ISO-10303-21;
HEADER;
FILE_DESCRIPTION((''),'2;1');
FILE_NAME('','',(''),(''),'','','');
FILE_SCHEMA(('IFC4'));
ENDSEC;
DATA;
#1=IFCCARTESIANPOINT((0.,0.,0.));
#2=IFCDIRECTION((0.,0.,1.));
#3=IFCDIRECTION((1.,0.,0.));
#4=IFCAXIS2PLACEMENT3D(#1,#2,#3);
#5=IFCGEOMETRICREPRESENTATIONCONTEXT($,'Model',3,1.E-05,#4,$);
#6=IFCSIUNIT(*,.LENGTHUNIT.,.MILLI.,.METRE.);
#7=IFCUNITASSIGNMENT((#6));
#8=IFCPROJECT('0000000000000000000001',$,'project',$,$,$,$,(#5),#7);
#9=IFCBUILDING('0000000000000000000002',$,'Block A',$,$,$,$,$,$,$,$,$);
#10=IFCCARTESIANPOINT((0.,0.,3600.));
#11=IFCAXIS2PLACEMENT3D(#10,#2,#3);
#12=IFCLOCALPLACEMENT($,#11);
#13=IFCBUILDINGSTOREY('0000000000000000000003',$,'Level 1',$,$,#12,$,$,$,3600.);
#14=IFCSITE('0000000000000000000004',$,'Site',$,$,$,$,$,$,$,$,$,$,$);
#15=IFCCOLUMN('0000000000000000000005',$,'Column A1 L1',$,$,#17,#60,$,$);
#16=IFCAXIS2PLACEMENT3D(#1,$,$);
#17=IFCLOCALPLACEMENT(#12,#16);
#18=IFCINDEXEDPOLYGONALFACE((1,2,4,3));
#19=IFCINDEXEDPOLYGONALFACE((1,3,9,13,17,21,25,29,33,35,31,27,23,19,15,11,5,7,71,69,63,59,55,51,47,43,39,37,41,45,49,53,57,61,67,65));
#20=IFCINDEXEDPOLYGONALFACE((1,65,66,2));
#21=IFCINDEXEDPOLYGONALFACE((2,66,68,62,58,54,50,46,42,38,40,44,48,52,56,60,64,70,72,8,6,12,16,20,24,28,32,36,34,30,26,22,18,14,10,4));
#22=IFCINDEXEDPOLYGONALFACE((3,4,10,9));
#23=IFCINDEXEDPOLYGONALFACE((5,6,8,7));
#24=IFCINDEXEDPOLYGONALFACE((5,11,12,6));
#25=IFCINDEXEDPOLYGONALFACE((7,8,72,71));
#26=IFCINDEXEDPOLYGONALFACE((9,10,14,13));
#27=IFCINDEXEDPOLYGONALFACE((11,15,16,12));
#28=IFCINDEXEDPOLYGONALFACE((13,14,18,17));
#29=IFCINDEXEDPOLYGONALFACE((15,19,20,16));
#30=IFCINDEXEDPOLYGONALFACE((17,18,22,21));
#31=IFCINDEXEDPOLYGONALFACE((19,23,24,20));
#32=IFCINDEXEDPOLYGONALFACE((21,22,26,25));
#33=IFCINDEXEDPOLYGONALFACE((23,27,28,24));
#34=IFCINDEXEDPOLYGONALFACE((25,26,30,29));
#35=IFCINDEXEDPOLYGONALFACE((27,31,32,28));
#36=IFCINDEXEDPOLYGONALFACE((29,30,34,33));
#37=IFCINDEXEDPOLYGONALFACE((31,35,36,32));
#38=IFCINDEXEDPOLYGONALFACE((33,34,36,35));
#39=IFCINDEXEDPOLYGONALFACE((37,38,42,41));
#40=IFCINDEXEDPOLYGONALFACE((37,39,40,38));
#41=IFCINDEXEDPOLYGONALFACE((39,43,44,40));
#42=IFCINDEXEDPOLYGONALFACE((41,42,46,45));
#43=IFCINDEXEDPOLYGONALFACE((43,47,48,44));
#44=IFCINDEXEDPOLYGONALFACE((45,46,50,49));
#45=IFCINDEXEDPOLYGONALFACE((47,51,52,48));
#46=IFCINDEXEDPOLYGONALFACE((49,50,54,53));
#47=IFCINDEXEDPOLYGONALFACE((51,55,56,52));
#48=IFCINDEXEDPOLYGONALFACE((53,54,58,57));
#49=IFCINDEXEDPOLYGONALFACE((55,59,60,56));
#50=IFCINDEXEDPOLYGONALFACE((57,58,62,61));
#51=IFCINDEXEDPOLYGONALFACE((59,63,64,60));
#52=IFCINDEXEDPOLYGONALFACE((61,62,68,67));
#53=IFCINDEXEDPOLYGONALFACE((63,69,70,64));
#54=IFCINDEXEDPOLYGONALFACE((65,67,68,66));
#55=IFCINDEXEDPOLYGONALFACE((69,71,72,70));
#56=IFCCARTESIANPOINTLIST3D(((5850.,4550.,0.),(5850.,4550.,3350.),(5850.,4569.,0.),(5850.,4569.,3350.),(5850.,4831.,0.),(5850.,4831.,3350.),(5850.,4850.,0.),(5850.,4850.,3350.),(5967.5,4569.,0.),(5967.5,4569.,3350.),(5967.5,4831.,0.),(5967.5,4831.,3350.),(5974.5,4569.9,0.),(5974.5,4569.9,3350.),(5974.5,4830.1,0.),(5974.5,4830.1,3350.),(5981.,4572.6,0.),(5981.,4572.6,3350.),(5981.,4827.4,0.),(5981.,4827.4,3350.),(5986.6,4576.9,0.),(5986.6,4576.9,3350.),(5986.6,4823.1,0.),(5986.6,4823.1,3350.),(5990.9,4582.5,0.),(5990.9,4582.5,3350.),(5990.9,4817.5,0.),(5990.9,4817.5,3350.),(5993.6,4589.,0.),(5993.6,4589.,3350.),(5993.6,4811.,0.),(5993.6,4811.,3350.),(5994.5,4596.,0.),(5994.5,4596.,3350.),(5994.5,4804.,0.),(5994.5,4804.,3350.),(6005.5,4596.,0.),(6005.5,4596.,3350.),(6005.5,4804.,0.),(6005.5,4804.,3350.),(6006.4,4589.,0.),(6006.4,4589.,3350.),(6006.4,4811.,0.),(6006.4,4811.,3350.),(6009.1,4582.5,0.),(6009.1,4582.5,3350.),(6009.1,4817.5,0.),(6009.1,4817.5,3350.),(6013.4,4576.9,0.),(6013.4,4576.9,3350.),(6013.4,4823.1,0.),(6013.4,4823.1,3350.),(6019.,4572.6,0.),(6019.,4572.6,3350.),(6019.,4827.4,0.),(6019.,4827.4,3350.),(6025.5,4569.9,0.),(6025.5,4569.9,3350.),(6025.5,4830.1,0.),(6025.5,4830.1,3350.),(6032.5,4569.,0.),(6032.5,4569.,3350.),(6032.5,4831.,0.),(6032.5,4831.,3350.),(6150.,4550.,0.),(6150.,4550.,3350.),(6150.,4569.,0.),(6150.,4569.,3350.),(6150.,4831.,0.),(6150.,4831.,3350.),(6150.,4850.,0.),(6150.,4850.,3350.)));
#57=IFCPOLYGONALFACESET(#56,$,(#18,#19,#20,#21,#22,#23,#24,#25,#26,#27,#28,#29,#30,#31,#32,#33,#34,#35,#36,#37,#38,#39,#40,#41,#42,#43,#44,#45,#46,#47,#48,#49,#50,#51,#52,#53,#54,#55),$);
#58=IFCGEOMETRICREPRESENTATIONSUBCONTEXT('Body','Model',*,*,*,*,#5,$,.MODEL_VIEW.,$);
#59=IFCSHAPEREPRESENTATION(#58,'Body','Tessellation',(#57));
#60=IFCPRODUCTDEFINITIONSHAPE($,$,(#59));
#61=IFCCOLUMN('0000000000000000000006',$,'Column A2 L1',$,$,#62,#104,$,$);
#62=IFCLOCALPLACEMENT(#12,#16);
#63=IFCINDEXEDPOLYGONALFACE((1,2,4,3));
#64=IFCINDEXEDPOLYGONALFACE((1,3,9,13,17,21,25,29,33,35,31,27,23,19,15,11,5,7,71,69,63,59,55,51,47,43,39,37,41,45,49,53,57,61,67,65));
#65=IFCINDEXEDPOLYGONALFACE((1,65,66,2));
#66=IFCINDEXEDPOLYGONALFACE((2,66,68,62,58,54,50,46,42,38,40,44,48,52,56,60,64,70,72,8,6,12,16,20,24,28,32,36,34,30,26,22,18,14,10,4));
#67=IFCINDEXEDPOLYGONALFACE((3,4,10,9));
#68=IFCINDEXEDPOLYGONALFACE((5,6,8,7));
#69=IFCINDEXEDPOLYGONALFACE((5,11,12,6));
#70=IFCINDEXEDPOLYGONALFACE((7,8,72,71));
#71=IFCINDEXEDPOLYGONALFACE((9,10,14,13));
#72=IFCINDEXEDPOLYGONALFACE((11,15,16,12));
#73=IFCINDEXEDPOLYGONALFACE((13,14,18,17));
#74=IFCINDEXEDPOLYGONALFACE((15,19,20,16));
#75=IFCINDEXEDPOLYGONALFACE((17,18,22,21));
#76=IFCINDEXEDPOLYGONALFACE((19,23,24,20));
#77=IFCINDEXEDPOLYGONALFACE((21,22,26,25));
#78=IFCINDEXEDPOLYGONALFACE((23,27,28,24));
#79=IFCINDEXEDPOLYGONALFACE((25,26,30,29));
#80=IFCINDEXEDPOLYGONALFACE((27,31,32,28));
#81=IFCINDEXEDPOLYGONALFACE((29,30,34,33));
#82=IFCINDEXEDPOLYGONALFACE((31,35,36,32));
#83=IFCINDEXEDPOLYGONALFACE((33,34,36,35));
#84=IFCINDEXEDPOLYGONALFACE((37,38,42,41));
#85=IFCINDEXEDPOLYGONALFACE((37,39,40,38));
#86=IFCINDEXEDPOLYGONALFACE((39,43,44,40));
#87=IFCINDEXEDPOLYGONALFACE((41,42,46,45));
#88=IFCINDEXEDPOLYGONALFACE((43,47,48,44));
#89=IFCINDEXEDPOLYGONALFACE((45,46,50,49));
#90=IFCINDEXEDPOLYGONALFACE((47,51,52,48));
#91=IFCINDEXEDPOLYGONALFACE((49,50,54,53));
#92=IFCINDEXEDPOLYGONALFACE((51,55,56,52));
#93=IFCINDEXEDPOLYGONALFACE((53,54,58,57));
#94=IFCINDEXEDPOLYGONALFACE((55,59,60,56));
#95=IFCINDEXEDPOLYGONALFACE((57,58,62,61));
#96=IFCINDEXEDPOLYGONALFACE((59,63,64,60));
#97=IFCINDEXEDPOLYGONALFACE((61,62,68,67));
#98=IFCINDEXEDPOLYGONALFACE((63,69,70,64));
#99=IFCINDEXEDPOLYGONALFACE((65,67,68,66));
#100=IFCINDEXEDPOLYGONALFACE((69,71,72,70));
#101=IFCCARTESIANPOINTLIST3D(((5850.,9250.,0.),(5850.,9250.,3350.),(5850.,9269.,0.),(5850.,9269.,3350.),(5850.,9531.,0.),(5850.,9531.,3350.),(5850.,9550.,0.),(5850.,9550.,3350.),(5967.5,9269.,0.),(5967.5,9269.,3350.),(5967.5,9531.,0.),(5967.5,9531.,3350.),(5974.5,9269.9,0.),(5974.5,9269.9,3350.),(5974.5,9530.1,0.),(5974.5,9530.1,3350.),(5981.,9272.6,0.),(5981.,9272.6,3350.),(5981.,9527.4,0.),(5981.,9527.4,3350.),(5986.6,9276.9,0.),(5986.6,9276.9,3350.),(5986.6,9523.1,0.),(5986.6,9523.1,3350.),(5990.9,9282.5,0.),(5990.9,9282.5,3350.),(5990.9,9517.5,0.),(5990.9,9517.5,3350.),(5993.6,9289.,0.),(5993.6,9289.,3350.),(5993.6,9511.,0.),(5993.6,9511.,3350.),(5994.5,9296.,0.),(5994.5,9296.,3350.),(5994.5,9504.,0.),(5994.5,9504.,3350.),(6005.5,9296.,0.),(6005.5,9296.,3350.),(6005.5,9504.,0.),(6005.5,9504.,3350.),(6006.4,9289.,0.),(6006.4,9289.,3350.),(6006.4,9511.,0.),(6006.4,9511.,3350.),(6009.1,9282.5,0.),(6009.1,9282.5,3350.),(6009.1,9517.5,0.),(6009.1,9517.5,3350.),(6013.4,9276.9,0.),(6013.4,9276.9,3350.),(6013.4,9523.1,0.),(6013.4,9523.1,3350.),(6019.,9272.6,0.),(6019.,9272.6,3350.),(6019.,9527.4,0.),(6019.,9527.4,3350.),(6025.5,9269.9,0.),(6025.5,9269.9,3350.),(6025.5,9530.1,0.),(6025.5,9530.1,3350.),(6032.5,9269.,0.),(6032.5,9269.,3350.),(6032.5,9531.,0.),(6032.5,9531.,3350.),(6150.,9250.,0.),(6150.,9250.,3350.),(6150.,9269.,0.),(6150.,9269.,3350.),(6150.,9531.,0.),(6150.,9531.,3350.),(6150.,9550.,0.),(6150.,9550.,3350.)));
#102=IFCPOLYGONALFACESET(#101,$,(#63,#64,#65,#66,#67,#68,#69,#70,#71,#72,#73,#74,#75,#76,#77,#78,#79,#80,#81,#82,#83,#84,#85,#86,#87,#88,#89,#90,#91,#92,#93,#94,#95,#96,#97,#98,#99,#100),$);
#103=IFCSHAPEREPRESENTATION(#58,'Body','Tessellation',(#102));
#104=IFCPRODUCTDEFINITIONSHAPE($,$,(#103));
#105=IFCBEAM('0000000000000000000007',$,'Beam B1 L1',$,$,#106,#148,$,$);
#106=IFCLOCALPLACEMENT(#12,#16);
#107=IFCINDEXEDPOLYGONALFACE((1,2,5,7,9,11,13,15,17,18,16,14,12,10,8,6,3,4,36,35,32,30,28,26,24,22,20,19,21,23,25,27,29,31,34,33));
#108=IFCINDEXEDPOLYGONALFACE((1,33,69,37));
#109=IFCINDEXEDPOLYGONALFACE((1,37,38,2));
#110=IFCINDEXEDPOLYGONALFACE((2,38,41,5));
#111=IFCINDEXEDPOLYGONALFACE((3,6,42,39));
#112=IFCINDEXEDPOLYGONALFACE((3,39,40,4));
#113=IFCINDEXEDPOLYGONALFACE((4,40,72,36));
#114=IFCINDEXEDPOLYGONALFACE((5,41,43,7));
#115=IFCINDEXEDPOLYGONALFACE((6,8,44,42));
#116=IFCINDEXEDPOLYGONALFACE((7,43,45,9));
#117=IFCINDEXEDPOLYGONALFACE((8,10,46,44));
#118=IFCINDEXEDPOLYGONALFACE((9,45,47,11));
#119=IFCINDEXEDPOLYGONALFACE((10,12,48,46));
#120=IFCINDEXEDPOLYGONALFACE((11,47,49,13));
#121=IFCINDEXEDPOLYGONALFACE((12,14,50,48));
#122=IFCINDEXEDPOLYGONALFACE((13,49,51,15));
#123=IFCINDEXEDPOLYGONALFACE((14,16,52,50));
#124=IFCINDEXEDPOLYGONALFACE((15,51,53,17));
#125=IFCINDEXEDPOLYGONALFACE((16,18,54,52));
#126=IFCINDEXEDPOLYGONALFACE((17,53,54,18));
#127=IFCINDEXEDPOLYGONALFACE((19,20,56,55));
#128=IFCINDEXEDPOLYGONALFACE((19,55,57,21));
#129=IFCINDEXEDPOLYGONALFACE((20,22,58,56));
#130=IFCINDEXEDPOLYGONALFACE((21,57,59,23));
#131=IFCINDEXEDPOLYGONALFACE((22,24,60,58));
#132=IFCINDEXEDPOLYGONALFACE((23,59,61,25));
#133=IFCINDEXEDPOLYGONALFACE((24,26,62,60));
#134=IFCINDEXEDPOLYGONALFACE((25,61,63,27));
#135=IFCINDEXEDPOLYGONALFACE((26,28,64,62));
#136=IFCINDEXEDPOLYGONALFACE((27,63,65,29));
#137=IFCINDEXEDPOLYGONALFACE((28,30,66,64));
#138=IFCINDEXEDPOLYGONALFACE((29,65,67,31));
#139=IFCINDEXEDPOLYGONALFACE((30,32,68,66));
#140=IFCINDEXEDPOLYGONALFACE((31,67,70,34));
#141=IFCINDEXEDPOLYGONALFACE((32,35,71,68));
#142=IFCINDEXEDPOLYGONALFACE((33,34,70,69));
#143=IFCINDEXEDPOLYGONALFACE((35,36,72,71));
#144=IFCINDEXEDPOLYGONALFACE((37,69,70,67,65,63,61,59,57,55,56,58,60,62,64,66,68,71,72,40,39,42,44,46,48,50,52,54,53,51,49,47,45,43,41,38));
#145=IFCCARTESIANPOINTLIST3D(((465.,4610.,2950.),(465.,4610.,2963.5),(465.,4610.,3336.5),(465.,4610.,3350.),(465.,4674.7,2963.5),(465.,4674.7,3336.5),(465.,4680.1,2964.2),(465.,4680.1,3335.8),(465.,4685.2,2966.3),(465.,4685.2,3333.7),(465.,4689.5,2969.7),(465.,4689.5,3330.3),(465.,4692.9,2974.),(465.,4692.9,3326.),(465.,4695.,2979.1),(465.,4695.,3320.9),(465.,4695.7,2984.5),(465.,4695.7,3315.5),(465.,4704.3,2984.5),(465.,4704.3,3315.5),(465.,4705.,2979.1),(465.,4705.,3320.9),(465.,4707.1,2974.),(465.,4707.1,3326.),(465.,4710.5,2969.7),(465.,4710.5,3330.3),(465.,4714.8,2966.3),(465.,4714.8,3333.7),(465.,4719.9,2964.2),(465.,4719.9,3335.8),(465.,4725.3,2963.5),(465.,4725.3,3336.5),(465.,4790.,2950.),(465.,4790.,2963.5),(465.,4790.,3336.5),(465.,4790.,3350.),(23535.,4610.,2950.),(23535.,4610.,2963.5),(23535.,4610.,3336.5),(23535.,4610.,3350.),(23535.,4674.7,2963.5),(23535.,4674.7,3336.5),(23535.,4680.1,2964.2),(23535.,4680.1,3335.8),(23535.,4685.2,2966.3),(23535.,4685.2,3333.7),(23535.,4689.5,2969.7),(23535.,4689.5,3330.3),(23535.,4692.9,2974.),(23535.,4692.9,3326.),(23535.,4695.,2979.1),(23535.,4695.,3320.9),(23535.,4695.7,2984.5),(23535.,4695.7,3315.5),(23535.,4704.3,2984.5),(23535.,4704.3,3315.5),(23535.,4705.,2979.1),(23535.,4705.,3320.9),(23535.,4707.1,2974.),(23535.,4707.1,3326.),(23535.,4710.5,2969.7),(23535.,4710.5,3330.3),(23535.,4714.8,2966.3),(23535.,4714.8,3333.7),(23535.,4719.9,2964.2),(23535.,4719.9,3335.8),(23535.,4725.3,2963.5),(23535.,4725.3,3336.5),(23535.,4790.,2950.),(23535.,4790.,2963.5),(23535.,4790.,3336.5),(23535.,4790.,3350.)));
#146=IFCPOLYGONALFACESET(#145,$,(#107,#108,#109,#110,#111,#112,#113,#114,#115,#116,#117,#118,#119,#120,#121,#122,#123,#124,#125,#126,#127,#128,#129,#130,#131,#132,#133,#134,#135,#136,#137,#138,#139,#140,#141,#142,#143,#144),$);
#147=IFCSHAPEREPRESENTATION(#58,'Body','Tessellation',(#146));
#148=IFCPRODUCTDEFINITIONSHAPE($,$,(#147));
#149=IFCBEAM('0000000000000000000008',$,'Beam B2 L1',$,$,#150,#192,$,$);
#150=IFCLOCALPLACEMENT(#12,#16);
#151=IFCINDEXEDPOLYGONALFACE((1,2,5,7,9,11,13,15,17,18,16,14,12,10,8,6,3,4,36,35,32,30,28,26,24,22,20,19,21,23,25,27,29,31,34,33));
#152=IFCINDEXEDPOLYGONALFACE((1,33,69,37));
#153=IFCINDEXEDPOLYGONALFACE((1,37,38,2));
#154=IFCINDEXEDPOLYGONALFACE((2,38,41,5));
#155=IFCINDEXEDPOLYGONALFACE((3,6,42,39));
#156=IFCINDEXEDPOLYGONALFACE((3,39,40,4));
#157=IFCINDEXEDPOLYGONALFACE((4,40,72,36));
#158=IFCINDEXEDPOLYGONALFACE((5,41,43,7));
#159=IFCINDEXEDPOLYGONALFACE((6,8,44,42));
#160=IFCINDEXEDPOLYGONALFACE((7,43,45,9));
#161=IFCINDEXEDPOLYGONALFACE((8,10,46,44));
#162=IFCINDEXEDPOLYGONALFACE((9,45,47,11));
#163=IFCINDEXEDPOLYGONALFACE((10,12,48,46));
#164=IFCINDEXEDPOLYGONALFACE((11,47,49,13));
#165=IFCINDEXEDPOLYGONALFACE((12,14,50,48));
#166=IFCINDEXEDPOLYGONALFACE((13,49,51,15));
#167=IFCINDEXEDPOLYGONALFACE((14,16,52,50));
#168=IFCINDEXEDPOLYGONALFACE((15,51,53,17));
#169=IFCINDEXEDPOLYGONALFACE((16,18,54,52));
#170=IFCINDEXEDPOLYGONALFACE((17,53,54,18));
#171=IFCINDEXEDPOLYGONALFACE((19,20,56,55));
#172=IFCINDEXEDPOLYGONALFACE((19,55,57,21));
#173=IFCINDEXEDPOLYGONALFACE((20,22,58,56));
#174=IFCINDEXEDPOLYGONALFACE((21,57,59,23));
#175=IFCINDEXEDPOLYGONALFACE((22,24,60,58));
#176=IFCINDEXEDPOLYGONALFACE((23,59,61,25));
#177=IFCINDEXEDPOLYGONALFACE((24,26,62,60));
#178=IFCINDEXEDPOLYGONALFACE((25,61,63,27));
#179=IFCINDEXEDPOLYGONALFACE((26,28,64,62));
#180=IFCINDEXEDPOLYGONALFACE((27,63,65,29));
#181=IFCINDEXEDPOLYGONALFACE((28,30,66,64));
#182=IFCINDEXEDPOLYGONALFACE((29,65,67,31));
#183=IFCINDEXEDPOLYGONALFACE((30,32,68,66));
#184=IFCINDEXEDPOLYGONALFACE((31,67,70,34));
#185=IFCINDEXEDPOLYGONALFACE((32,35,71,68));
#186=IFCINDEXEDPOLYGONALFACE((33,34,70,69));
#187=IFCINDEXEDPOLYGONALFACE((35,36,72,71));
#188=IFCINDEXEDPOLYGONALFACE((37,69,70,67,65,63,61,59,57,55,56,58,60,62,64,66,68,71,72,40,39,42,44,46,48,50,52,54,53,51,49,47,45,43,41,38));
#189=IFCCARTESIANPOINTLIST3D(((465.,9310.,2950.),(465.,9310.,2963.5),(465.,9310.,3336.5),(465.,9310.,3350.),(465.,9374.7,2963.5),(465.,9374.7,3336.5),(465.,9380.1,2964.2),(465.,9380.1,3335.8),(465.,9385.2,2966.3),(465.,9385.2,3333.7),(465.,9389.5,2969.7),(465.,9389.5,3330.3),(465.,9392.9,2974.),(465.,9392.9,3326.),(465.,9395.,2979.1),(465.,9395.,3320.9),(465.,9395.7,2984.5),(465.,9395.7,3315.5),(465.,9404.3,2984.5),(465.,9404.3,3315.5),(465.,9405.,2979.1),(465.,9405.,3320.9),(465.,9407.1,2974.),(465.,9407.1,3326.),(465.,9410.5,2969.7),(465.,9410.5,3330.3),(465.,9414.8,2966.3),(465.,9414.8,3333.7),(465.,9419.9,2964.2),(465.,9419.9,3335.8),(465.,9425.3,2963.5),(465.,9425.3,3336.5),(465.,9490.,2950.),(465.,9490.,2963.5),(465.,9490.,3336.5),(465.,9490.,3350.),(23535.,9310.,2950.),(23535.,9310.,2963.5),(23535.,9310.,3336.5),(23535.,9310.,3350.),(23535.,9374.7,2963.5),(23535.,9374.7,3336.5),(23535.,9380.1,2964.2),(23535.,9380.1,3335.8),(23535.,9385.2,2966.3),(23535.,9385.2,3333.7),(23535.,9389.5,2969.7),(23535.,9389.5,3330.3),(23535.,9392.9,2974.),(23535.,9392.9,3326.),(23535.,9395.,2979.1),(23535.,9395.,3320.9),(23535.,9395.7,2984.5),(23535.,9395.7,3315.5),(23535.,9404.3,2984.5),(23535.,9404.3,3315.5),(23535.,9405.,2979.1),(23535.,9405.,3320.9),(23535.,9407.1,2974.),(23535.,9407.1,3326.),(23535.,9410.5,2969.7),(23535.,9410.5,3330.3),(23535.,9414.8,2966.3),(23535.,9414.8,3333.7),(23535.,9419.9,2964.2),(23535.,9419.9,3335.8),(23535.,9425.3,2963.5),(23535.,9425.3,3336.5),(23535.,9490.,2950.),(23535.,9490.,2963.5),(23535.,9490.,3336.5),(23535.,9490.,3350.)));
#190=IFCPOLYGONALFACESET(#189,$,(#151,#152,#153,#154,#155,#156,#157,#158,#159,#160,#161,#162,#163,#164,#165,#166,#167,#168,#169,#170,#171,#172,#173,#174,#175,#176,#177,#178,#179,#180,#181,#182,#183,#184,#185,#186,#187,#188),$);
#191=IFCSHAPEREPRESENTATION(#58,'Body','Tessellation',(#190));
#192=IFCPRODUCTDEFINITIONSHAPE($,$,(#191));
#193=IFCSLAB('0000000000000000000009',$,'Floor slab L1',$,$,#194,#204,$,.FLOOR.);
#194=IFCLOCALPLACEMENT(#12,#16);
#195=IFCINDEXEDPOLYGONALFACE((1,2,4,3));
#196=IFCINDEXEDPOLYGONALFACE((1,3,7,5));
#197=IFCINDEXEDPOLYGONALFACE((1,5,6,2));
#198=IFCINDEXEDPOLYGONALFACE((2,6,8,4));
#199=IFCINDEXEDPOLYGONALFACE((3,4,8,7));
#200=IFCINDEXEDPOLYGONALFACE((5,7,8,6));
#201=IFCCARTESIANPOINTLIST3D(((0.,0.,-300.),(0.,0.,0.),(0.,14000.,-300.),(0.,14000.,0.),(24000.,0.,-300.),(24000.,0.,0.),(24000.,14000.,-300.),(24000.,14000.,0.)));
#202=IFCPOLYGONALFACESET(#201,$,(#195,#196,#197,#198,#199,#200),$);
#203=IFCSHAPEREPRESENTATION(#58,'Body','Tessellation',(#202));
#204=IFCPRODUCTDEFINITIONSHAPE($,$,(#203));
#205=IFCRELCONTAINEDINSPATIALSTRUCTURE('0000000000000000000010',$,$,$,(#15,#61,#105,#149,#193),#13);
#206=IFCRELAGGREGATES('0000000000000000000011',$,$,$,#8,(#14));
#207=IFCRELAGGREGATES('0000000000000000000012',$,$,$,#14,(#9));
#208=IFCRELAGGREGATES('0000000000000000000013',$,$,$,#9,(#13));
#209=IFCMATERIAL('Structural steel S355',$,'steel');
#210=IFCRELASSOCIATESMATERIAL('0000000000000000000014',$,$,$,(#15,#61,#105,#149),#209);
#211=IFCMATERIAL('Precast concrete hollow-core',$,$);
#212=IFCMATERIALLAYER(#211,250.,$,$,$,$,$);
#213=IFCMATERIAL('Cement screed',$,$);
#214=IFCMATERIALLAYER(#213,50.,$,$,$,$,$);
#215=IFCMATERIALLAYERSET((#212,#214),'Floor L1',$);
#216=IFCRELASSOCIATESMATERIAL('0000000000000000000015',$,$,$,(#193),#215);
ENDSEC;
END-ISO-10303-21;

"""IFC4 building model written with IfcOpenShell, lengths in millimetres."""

from ifc_helpers import new_model, si_unit, frame, origin_with_axes, place, context, subcontext, project, spatial, indexed_curve, i_section, outline, extrude, material, layer, layer_set, layer_usage, material_profile, profile_set, element, save


model = new_model("IFC4")

# Units and contexts
model_context = context("Model", 3, precision=1e-05, world=origin_with_axes())
body_context = subcontext(model_context, "Body", "Model", "MODEL_VIEW")
ifc_project = project(units=[si_unit("LENGTHUNIT", "METRE", prefix="MILLI")], contexts=[model_context])

# Site, building, storey
site = spatial("IfcSite", under=ifc_project, Name="Site")
building = spatial("IfcBuilding", under=site, Name="Block A")
storey_placement = place(None, frame((0.0, 0.0, 3600.0), z_axis=(0.0, 0.0, 1.0), x_axis=(1.0, 0.0, 0.0)))
storey = spatial("IfcBuildingStorey", under=building, at=storey_placement, Name="Level 1", Elevation=3600.0)

# Columns
ifc_material_1 = material(Name="Structural steel S355", Category="steel")
ifc_material_profile_1 = material_profile(ifc_material_1, i_section(OverallWidth=300.0, OverallDepth=300.0, WebThickness=11.0, FlangeThickness=19.0, FilletRadius=27.0))
ifc_profile_set_1 = profile_set([ifc_material_profile_1], Name="HEB 300")
for number, where, z_axis, x_axis, name in (
    (1, (6000.0, 4700.0, 0.0), (0.0, 0.0, 1.0), (1.0, 0.0, 0.0), "Column A1 L1"),
    (2, (6000.0, 9400.0, 0.0), (0.0, 0.0, 1.0), (1.0, 0.0, 0.0), "Column A2 L1"),
):
    element("IfcColumn", number, at=place(storey_placement, frame(where, z_axis=z_axis, x_axis=x_axis)), inside=storey, material=ifc_profile_set_1, Name=name, context=body_context, shape_type="SweptSolid", body=[
        extrude(i_section(OverallWidth=300.0, OverallDepth=300.0, WebThickness=11.0, FlangeThickness=19.0, FilletRadius=27.0), origin_with_axes(), (0.0, 0.0, 1.0), 3350.0),
    ])

# Beams
ifc_material_profile_2 = material_profile(ifc_material_1, i_section(OverallWidth=180.0, OverallDepth=400.0, WebThickness=8.6, FlangeThickness=13.5, FilletRadius=21.0))
ifc_profile_set_2 = profile_set([ifc_material_profile_2], Name="IPE 400")
for number, where, z_axis, x_axis, name in (
    (3, (465.0, 4700.0, 3150.0), (1.0, 0.0, 0.0), (0.0, 1.0, 0.0), "Beam B1 L1"),
    (4, (465.0, 9400.0, 3150.0), (1.0, 0.0, 0.0), (0.0, 1.0, 0.0), "Beam B2 L1"),
):
    element("IfcBeam", number, at=place(storey_placement, frame(where, z_axis=z_axis, x_axis=x_axis)), inside=storey, material=ifc_profile_set_2, Name=name, context=body_context, shape_type="SweptSolid", body=[
        extrude(i_section(OverallWidth=180.0, OverallDepth=400.0, WebThickness=8.6, FlangeThickness=13.5, FilletRadius=21.0), origin_with_axes(), (0.0, 0.0, 1.0), 23070.0),
    ])

# Slab
ifc_material_2 = material(Name="Precast concrete hollow-core")
ifc_layer_1 = layer(ifc_material_2, 250.0)
ifc_material_3 = material(Name="Cement screed")
ifc_layer_2 = layer(ifc_material_3, 50.0)
ifc_layer_set_1 = layer_set([ifc_layer_1, ifc_layer_2], Name="Floor L1")
ifc_layer_usage_1 = layer_usage(ifc_layer_set_1, "AXIS3", "POSITIVE", 0.0)
slab_placement = place(storey_placement, frame((0.0, 0.0, -300.0), z_axis=(0.0, 0.0, 1.0), x_axis=(1.0, 0.0, 0.0)))
element("IfcSlab", 5, at=slab_placement, inside=storey, material=ifc_layer_usage_1, Name="Floor slab L1", PredefinedType="FLOOR", context=body_context, shape_type="SweptSolid", body=[
    extrude(outline(indexed_curve([(0.0, 0.0), (24000.0, 0.0), (24000.0, 14000.0), (0.0, 14000.0), (0.0, 0.0)])), None, (0.0, 0.0, 1.0), 300.0),
])

save(model, "model.ifc")
